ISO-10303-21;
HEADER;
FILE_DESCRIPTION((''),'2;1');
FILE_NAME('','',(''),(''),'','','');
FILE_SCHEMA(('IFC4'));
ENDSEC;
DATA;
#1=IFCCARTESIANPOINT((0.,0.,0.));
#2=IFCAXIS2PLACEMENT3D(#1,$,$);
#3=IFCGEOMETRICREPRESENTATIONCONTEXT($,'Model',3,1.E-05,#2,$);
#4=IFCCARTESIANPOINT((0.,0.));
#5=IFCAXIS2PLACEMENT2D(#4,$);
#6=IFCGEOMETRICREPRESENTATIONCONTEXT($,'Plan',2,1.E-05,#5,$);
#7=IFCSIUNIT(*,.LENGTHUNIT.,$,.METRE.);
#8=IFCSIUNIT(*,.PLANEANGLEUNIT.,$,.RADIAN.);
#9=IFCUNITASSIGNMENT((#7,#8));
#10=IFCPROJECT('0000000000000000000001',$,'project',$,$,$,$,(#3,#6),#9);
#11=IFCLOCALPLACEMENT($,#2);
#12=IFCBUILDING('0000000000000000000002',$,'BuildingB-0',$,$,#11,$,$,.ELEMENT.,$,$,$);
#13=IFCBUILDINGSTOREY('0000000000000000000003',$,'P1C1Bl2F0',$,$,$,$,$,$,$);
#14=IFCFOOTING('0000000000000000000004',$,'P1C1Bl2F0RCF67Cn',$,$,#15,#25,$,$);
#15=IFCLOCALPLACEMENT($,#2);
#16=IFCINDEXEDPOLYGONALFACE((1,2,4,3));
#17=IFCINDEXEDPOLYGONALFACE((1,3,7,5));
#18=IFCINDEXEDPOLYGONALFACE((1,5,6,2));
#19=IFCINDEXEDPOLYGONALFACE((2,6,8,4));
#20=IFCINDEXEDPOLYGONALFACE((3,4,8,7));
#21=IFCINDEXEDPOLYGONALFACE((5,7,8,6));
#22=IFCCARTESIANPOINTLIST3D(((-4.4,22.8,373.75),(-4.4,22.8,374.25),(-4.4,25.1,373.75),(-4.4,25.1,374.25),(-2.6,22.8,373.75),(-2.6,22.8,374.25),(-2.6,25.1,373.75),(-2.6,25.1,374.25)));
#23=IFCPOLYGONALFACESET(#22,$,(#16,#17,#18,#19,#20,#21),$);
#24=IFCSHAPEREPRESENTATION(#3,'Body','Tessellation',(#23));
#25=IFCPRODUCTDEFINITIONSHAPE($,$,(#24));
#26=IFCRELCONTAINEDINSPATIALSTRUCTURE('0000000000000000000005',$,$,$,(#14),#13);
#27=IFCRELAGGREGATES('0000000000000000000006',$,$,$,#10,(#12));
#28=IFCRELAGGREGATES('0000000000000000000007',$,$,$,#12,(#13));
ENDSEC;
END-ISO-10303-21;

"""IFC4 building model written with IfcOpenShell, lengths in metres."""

from ifc_helpers import new_model, si_unit, origin, origin_2d, place, context, project, spatial, polyline, outline, extrude, element, save


model = new_model("IFC4")

# Units and contexts
model_context = context("Model", 3, precision=1e-05, world=origin())
plan_context = context("Plan", 2, precision=1e-05, world=origin_2d())
ifc_project = project(units=[si_unit("LENGTHUNIT", "METRE"), si_unit("PLANEANGLEUNIT", "RADIAN")], contexts=[model_context, plan_context])

# Building, storey
building_placement = place(None, origin())
building = spatial("IfcBuilding", under=ifc_project, at=building_placement, Name="BuildingB-0", CompositionType="ELEMENT")
storey = spatial("IfcBuildingStorey", under=building, Name="P1C1Bl2F0")

# Footing
element("IfcFooting", 1, inside=storey, Name="P1C1Bl2F0RCF67Cn", context=model_context, shape_type="SweptSolid", body=[
    extrude(outline(polyline([(-4.4, 25.1, 373.75), (-2.6, 25.1, 373.75), (-2.6, 22.8, 373.75), (-4.4, 22.8, 373.75), (-4.4, 25.1, 373.75)])), None, (0.0, 0.0, 1.0), 0.5),
])

save(model, "model.ifc")
